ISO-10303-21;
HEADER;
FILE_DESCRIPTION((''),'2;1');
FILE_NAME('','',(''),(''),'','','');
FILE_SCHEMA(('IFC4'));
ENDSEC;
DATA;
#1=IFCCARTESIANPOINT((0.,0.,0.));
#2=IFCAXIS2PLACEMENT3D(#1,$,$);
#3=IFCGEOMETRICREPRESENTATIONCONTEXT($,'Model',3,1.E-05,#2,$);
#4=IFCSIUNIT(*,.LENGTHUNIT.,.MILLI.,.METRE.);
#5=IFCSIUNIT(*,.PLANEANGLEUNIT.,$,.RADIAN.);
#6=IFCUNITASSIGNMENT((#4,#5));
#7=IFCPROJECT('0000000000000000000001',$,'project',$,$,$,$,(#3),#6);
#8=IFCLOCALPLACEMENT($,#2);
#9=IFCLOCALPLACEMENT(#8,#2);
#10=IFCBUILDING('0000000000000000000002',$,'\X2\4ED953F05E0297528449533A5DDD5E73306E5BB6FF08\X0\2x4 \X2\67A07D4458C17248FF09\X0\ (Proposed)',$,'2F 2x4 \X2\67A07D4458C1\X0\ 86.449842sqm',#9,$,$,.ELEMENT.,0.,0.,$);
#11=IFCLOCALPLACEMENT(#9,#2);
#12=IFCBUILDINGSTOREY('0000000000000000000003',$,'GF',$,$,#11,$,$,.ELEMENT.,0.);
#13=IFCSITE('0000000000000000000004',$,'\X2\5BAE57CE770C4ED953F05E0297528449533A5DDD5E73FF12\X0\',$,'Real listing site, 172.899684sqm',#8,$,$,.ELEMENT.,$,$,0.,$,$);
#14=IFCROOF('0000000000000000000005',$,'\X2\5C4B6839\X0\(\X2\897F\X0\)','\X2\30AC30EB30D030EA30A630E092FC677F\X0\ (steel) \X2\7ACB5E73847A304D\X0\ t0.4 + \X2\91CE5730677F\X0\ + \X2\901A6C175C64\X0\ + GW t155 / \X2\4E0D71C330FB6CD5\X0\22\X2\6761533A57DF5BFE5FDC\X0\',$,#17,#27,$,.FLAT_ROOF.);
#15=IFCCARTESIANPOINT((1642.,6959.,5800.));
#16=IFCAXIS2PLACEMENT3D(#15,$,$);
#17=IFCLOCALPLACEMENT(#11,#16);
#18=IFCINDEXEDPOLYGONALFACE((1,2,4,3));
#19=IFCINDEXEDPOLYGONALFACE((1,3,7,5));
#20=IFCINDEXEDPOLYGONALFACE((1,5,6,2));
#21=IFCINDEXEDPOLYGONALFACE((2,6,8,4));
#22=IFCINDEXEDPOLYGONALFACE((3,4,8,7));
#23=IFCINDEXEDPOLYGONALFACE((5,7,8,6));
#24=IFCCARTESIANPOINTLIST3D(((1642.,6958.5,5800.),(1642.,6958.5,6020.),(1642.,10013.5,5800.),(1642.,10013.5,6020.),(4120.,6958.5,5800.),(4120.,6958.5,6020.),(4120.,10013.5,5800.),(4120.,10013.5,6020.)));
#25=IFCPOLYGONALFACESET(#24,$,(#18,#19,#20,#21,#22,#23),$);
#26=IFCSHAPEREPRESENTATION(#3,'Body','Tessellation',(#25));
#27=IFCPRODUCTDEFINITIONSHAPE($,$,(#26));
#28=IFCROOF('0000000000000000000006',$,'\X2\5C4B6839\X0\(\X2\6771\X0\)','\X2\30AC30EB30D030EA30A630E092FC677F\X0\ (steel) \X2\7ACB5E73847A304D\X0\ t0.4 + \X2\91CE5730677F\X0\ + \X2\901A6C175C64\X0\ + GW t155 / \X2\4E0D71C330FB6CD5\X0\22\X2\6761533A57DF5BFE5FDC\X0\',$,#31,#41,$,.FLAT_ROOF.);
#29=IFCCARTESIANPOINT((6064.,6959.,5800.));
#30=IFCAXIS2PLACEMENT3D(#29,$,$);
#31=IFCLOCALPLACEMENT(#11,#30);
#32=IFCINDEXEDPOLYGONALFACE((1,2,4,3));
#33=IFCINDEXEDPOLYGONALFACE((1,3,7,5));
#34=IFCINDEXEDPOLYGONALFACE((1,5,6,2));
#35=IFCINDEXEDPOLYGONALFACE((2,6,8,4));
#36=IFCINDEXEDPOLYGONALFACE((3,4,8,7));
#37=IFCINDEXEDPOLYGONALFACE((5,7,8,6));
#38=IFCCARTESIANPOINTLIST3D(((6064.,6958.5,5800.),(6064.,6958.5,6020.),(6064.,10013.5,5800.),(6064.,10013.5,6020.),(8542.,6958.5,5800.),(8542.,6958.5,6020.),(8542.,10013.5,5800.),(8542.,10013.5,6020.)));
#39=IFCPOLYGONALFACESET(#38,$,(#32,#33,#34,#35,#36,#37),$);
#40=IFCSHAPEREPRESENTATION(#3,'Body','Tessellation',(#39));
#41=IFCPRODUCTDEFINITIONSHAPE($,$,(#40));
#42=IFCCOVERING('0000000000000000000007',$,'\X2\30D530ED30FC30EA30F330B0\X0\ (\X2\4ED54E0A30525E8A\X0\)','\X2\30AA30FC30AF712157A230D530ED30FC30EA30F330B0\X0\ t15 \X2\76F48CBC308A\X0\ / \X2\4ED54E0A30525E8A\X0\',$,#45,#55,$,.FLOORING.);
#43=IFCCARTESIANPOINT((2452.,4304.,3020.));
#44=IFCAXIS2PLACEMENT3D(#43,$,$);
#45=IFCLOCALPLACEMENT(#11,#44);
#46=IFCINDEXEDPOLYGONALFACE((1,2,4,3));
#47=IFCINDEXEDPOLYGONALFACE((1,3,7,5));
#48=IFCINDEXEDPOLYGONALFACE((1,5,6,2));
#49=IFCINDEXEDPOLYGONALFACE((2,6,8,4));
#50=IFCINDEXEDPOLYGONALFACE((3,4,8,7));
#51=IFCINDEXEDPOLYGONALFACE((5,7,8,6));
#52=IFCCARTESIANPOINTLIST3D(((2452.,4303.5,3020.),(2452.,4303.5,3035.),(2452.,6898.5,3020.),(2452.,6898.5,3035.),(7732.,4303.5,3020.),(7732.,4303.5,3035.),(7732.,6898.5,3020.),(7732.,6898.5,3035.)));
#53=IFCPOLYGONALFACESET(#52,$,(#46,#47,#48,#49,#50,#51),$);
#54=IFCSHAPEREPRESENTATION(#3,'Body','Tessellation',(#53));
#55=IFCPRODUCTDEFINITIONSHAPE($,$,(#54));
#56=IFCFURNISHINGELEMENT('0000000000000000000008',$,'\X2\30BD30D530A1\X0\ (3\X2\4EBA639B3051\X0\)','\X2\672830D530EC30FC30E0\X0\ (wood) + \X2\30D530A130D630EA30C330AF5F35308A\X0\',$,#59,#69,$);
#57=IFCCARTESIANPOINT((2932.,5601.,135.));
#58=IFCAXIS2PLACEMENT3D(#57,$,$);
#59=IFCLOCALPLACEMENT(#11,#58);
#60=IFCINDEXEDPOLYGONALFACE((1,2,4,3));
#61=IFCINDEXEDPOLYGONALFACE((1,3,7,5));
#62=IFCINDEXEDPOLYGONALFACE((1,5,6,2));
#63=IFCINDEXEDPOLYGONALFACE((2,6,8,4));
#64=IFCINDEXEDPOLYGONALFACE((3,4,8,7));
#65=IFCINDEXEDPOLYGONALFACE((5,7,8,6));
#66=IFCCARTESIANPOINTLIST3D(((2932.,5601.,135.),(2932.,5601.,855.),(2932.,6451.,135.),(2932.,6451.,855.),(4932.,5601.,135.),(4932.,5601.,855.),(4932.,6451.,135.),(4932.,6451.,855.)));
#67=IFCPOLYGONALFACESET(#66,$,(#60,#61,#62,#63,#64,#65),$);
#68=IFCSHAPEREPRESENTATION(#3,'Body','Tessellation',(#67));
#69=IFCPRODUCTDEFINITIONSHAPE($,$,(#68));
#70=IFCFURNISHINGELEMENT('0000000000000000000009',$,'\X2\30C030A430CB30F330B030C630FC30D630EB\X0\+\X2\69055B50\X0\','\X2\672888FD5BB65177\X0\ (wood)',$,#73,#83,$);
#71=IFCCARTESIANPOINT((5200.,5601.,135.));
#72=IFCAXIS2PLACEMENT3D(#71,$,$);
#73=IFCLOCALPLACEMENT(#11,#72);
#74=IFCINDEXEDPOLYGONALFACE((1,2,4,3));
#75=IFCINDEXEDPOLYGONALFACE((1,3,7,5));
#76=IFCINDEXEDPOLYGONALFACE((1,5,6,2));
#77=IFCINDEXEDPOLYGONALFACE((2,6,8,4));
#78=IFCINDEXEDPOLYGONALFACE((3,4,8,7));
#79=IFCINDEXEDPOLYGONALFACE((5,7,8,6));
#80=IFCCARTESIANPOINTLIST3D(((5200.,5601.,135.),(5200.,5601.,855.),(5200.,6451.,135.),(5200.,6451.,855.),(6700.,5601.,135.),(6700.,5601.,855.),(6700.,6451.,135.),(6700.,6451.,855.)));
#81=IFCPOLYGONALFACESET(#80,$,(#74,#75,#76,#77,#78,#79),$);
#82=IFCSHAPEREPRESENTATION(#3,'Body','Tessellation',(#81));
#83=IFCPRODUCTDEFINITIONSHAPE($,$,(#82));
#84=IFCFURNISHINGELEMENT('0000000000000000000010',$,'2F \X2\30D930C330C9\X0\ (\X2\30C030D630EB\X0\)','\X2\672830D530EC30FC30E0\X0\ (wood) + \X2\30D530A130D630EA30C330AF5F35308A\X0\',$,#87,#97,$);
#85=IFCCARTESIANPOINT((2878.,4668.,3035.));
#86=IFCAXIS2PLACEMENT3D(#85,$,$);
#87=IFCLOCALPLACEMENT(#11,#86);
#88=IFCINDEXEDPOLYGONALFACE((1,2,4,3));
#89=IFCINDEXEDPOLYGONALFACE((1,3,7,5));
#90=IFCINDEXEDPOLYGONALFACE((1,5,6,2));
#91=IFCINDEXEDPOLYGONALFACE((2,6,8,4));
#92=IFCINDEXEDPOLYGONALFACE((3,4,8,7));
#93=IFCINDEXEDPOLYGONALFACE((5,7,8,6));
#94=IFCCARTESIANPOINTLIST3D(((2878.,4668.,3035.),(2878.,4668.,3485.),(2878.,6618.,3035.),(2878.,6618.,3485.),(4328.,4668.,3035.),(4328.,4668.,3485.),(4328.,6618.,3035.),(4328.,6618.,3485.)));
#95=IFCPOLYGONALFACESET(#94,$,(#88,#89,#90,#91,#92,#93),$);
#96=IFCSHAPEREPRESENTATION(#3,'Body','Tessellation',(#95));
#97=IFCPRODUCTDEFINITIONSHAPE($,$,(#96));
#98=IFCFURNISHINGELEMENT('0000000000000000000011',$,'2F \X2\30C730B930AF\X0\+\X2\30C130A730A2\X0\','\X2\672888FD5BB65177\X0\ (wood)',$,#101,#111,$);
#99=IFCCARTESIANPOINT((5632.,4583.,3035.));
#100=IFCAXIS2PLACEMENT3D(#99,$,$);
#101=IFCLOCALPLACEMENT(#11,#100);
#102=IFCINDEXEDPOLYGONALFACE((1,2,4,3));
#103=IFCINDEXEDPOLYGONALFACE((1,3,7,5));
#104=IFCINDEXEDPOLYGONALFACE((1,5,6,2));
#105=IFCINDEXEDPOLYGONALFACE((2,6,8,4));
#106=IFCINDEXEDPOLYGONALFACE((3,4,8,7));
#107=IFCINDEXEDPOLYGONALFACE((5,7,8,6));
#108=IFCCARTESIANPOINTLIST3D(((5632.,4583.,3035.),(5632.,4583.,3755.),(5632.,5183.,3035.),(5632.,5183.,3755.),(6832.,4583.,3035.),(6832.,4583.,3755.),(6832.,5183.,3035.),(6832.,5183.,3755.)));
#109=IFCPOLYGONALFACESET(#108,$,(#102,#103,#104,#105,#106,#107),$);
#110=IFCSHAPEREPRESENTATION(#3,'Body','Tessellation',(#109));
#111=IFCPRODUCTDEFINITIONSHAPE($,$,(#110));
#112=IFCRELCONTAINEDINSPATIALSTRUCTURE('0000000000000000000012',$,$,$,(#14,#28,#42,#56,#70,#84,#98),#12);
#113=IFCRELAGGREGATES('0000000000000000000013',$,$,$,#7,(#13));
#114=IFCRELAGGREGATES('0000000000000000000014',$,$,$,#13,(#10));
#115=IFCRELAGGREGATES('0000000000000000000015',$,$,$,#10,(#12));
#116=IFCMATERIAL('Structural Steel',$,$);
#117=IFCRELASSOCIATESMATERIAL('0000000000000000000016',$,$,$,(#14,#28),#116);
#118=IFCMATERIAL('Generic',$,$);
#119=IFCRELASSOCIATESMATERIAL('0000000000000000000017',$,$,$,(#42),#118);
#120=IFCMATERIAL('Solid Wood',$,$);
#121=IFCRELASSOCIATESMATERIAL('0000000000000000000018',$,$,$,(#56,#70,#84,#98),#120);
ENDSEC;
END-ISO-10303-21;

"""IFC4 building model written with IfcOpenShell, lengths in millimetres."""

from ifc_helpers import new_model, si_unit, frame, frame_2d, origin, place, context, project, spatial, rectangle, extrude, material, element, save


model = new_model("IFC4")

# Units and contexts
model_context = context("Model", 3, precision=1e-05, world=origin())
ifc_project = project(units=[si_unit("LENGTHUNIT", "METRE", prefix="MILLI"), si_unit("PLANEANGLEUNIT", "RADIAN")], contexts=[model_context])

# Site, building, storey
site_placement = place(None, origin())
site = spatial("IfcSite", under=ifc_project, at=site_placement, Name="宮城県仙台市青葉区川平２", ObjectType="Real listing site, 172.899684sqm", CompositionType="ELEMENT", RefElevation=0.0)
building_placement = place(site_placement, origin())
building = spatial("IfcBuilding", under=site, at=building_placement, Name="仙台市青葉区川平の家（2x4 枠組壁版） (Proposed)", ObjectType="2F 2x4 枠組壁 86.449842sqm", CompositionType="ELEMENT", ElevationOfRefHeight=0.0, ElevationOfTerrain=0.0)
storey_placement = place(building_placement, origin())
storey = spatial("IfcBuildingStorey", under=building, at=storey_placement, Name="GF", CompositionType="ELEMENT", Elevation=0.0)

# Shared definitions
ifc_material_1 = material(Name="Solid Wood")

# Roofs
ifc_material_2 = material(Name="Structural Steel")
roof_1_placement = place(storey_placement, frame((1642.0, 6959.0, 5800.0)))
element("IfcRoof", 1, at=roof_1_placement, inside=storey, material=ifc_material_2, Name="屋根(西)", Description="ガルバリウム鋼板 (steel) 立平葺き t0.4 + 野地板 + 通気層 + GW t155 / 不燃・法22条区域対応", PredefinedType="FLAT_ROOF", context=model_context, shape_type="SweptSolid", body=[
    extrude(rectangle(XDim=2478.0, YDim=3055.0, at=frame_2d((1239.0, 1527.0))), frame((1642.0, 6959.0, 5800.0)), (0.0, 0.0, 1.0), 220.0),
])
roof_2_placement = place(storey_placement, frame((6064.0, 6959.0, 5800.0)))
element("IfcRoof", 2, at=roof_2_placement, inside=storey, material=ifc_material_2, Name="屋根(東)", Description="ガルバリウム鋼板 (steel) 立平葺き t0.4 + 野地板 + 通気層 + GW t155 / 不燃・法22条区域対応", PredefinedType="FLAT_ROOF", context=model_context, shape_type="SweptSolid", body=[
    extrude(rectangle(XDim=2478.0, YDim=3055.0, at=frame_2d((1239.0, 1527.0))), frame((6064.0, 6959.0, 5800.0)), (0.0, 0.0, 1.0), 220.0),
])

# Covering
ifc_material_3 = material(Name="Generic")
covering_placement = place(storey_placement, frame((2452.0, 4304.0, 3020.0)))
element("IfcCovering", 3, at=covering_placement, inside=storey, material=ifc_material_3, Name="フローリング (仕上げ床)", Description="オーク無垢フローリング t15 直貼り / 仕上げ床", PredefinedType="FLOORING", context=model_context, shape_type="SweptSolid", body=[
    extrude(rectangle(XDim=5280.0, YDim=2595.0, at=frame_2d((2640.0, 1297.0))), frame((2452.0, 4304.0, 3020.0)), (0.0, 0.0, 1.0), 15.0),
])

# Furnishing elements
furnishing_1_placement = place(storey_placement, frame((2932.0, 5601.0, 135.0)))
element("IfcFurnishingElement", 4, at=furnishing_1_placement, inside=storey, material=ifc_material_1, Name="ソファ (3人掛け)", Description="木フレーム (wood) + ファブリック張り", context=model_context, shape_type="SweptSolid", body=[
    extrude(rectangle(XDim=2000.0, YDim=850.0, at=frame_2d((1000.0, 425.0))), frame((2932.0, 5601.0, 135.0)), (0.0, 0.0, 1.0), 720.0),
])
furnishing_2_placement = place(storey_placement, frame((5200.0, 5601.0, 135.0)))
element("IfcFurnishingElement", 5, at=furnishing_2_placement, inside=storey, material=ifc_material_1, Name="ダイニングテーブル+椅子", Description="木製家具 (wood)", context=model_context, shape_type="SweptSolid", body=[
    extrude(rectangle(XDim=1500.0, YDim=850.0, at=frame_2d((750.0, 425.0))), frame((5200.0, 5601.0, 135.0)), (0.0, 0.0, 1.0), 720.0),
])
furnishing_3_placement = place(storey_placement, frame((2878.0, 4668.0, 3035.0)))
element("IfcFurnishingElement", 6, at=furnishing_3_placement, inside=storey, material=ifc_material_1, Name="2F ベッド (ダブル)", Description="木フレーム (wood) + ファブリック張り", context=model_context, shape_type="SweptSolid", body=[
    extrude(rectangle(XDim=1450.0, YDim=1950.0, at=frame_2d((725.0, 975.0))), frame((2878.0, 4668.0, 3035.0)), (0.0, 0.0, 1.0), 450.0),
])
furnishing_4_placement = place(storey_placement, frame((5632.0, 4583.0, 3035.0)))
element("IfcFurnishingElement", 7, at=furnishing_4_placement, inside=storey, material=ifc_material_1, Name="2F デスク+チェア", Description="木製家具 (wood)", context=model_context, shape_type="SweptSolid", body=[
    extrude(rectangle(XDim=1200.0, YDim=600.0, at=frame_2d((600.0, 300.0))), frame((5632.0, 4583.0, 3035.0)), (0.0, 0.0, 1.0), 720.0),
])

save(model, "model.ifc")
